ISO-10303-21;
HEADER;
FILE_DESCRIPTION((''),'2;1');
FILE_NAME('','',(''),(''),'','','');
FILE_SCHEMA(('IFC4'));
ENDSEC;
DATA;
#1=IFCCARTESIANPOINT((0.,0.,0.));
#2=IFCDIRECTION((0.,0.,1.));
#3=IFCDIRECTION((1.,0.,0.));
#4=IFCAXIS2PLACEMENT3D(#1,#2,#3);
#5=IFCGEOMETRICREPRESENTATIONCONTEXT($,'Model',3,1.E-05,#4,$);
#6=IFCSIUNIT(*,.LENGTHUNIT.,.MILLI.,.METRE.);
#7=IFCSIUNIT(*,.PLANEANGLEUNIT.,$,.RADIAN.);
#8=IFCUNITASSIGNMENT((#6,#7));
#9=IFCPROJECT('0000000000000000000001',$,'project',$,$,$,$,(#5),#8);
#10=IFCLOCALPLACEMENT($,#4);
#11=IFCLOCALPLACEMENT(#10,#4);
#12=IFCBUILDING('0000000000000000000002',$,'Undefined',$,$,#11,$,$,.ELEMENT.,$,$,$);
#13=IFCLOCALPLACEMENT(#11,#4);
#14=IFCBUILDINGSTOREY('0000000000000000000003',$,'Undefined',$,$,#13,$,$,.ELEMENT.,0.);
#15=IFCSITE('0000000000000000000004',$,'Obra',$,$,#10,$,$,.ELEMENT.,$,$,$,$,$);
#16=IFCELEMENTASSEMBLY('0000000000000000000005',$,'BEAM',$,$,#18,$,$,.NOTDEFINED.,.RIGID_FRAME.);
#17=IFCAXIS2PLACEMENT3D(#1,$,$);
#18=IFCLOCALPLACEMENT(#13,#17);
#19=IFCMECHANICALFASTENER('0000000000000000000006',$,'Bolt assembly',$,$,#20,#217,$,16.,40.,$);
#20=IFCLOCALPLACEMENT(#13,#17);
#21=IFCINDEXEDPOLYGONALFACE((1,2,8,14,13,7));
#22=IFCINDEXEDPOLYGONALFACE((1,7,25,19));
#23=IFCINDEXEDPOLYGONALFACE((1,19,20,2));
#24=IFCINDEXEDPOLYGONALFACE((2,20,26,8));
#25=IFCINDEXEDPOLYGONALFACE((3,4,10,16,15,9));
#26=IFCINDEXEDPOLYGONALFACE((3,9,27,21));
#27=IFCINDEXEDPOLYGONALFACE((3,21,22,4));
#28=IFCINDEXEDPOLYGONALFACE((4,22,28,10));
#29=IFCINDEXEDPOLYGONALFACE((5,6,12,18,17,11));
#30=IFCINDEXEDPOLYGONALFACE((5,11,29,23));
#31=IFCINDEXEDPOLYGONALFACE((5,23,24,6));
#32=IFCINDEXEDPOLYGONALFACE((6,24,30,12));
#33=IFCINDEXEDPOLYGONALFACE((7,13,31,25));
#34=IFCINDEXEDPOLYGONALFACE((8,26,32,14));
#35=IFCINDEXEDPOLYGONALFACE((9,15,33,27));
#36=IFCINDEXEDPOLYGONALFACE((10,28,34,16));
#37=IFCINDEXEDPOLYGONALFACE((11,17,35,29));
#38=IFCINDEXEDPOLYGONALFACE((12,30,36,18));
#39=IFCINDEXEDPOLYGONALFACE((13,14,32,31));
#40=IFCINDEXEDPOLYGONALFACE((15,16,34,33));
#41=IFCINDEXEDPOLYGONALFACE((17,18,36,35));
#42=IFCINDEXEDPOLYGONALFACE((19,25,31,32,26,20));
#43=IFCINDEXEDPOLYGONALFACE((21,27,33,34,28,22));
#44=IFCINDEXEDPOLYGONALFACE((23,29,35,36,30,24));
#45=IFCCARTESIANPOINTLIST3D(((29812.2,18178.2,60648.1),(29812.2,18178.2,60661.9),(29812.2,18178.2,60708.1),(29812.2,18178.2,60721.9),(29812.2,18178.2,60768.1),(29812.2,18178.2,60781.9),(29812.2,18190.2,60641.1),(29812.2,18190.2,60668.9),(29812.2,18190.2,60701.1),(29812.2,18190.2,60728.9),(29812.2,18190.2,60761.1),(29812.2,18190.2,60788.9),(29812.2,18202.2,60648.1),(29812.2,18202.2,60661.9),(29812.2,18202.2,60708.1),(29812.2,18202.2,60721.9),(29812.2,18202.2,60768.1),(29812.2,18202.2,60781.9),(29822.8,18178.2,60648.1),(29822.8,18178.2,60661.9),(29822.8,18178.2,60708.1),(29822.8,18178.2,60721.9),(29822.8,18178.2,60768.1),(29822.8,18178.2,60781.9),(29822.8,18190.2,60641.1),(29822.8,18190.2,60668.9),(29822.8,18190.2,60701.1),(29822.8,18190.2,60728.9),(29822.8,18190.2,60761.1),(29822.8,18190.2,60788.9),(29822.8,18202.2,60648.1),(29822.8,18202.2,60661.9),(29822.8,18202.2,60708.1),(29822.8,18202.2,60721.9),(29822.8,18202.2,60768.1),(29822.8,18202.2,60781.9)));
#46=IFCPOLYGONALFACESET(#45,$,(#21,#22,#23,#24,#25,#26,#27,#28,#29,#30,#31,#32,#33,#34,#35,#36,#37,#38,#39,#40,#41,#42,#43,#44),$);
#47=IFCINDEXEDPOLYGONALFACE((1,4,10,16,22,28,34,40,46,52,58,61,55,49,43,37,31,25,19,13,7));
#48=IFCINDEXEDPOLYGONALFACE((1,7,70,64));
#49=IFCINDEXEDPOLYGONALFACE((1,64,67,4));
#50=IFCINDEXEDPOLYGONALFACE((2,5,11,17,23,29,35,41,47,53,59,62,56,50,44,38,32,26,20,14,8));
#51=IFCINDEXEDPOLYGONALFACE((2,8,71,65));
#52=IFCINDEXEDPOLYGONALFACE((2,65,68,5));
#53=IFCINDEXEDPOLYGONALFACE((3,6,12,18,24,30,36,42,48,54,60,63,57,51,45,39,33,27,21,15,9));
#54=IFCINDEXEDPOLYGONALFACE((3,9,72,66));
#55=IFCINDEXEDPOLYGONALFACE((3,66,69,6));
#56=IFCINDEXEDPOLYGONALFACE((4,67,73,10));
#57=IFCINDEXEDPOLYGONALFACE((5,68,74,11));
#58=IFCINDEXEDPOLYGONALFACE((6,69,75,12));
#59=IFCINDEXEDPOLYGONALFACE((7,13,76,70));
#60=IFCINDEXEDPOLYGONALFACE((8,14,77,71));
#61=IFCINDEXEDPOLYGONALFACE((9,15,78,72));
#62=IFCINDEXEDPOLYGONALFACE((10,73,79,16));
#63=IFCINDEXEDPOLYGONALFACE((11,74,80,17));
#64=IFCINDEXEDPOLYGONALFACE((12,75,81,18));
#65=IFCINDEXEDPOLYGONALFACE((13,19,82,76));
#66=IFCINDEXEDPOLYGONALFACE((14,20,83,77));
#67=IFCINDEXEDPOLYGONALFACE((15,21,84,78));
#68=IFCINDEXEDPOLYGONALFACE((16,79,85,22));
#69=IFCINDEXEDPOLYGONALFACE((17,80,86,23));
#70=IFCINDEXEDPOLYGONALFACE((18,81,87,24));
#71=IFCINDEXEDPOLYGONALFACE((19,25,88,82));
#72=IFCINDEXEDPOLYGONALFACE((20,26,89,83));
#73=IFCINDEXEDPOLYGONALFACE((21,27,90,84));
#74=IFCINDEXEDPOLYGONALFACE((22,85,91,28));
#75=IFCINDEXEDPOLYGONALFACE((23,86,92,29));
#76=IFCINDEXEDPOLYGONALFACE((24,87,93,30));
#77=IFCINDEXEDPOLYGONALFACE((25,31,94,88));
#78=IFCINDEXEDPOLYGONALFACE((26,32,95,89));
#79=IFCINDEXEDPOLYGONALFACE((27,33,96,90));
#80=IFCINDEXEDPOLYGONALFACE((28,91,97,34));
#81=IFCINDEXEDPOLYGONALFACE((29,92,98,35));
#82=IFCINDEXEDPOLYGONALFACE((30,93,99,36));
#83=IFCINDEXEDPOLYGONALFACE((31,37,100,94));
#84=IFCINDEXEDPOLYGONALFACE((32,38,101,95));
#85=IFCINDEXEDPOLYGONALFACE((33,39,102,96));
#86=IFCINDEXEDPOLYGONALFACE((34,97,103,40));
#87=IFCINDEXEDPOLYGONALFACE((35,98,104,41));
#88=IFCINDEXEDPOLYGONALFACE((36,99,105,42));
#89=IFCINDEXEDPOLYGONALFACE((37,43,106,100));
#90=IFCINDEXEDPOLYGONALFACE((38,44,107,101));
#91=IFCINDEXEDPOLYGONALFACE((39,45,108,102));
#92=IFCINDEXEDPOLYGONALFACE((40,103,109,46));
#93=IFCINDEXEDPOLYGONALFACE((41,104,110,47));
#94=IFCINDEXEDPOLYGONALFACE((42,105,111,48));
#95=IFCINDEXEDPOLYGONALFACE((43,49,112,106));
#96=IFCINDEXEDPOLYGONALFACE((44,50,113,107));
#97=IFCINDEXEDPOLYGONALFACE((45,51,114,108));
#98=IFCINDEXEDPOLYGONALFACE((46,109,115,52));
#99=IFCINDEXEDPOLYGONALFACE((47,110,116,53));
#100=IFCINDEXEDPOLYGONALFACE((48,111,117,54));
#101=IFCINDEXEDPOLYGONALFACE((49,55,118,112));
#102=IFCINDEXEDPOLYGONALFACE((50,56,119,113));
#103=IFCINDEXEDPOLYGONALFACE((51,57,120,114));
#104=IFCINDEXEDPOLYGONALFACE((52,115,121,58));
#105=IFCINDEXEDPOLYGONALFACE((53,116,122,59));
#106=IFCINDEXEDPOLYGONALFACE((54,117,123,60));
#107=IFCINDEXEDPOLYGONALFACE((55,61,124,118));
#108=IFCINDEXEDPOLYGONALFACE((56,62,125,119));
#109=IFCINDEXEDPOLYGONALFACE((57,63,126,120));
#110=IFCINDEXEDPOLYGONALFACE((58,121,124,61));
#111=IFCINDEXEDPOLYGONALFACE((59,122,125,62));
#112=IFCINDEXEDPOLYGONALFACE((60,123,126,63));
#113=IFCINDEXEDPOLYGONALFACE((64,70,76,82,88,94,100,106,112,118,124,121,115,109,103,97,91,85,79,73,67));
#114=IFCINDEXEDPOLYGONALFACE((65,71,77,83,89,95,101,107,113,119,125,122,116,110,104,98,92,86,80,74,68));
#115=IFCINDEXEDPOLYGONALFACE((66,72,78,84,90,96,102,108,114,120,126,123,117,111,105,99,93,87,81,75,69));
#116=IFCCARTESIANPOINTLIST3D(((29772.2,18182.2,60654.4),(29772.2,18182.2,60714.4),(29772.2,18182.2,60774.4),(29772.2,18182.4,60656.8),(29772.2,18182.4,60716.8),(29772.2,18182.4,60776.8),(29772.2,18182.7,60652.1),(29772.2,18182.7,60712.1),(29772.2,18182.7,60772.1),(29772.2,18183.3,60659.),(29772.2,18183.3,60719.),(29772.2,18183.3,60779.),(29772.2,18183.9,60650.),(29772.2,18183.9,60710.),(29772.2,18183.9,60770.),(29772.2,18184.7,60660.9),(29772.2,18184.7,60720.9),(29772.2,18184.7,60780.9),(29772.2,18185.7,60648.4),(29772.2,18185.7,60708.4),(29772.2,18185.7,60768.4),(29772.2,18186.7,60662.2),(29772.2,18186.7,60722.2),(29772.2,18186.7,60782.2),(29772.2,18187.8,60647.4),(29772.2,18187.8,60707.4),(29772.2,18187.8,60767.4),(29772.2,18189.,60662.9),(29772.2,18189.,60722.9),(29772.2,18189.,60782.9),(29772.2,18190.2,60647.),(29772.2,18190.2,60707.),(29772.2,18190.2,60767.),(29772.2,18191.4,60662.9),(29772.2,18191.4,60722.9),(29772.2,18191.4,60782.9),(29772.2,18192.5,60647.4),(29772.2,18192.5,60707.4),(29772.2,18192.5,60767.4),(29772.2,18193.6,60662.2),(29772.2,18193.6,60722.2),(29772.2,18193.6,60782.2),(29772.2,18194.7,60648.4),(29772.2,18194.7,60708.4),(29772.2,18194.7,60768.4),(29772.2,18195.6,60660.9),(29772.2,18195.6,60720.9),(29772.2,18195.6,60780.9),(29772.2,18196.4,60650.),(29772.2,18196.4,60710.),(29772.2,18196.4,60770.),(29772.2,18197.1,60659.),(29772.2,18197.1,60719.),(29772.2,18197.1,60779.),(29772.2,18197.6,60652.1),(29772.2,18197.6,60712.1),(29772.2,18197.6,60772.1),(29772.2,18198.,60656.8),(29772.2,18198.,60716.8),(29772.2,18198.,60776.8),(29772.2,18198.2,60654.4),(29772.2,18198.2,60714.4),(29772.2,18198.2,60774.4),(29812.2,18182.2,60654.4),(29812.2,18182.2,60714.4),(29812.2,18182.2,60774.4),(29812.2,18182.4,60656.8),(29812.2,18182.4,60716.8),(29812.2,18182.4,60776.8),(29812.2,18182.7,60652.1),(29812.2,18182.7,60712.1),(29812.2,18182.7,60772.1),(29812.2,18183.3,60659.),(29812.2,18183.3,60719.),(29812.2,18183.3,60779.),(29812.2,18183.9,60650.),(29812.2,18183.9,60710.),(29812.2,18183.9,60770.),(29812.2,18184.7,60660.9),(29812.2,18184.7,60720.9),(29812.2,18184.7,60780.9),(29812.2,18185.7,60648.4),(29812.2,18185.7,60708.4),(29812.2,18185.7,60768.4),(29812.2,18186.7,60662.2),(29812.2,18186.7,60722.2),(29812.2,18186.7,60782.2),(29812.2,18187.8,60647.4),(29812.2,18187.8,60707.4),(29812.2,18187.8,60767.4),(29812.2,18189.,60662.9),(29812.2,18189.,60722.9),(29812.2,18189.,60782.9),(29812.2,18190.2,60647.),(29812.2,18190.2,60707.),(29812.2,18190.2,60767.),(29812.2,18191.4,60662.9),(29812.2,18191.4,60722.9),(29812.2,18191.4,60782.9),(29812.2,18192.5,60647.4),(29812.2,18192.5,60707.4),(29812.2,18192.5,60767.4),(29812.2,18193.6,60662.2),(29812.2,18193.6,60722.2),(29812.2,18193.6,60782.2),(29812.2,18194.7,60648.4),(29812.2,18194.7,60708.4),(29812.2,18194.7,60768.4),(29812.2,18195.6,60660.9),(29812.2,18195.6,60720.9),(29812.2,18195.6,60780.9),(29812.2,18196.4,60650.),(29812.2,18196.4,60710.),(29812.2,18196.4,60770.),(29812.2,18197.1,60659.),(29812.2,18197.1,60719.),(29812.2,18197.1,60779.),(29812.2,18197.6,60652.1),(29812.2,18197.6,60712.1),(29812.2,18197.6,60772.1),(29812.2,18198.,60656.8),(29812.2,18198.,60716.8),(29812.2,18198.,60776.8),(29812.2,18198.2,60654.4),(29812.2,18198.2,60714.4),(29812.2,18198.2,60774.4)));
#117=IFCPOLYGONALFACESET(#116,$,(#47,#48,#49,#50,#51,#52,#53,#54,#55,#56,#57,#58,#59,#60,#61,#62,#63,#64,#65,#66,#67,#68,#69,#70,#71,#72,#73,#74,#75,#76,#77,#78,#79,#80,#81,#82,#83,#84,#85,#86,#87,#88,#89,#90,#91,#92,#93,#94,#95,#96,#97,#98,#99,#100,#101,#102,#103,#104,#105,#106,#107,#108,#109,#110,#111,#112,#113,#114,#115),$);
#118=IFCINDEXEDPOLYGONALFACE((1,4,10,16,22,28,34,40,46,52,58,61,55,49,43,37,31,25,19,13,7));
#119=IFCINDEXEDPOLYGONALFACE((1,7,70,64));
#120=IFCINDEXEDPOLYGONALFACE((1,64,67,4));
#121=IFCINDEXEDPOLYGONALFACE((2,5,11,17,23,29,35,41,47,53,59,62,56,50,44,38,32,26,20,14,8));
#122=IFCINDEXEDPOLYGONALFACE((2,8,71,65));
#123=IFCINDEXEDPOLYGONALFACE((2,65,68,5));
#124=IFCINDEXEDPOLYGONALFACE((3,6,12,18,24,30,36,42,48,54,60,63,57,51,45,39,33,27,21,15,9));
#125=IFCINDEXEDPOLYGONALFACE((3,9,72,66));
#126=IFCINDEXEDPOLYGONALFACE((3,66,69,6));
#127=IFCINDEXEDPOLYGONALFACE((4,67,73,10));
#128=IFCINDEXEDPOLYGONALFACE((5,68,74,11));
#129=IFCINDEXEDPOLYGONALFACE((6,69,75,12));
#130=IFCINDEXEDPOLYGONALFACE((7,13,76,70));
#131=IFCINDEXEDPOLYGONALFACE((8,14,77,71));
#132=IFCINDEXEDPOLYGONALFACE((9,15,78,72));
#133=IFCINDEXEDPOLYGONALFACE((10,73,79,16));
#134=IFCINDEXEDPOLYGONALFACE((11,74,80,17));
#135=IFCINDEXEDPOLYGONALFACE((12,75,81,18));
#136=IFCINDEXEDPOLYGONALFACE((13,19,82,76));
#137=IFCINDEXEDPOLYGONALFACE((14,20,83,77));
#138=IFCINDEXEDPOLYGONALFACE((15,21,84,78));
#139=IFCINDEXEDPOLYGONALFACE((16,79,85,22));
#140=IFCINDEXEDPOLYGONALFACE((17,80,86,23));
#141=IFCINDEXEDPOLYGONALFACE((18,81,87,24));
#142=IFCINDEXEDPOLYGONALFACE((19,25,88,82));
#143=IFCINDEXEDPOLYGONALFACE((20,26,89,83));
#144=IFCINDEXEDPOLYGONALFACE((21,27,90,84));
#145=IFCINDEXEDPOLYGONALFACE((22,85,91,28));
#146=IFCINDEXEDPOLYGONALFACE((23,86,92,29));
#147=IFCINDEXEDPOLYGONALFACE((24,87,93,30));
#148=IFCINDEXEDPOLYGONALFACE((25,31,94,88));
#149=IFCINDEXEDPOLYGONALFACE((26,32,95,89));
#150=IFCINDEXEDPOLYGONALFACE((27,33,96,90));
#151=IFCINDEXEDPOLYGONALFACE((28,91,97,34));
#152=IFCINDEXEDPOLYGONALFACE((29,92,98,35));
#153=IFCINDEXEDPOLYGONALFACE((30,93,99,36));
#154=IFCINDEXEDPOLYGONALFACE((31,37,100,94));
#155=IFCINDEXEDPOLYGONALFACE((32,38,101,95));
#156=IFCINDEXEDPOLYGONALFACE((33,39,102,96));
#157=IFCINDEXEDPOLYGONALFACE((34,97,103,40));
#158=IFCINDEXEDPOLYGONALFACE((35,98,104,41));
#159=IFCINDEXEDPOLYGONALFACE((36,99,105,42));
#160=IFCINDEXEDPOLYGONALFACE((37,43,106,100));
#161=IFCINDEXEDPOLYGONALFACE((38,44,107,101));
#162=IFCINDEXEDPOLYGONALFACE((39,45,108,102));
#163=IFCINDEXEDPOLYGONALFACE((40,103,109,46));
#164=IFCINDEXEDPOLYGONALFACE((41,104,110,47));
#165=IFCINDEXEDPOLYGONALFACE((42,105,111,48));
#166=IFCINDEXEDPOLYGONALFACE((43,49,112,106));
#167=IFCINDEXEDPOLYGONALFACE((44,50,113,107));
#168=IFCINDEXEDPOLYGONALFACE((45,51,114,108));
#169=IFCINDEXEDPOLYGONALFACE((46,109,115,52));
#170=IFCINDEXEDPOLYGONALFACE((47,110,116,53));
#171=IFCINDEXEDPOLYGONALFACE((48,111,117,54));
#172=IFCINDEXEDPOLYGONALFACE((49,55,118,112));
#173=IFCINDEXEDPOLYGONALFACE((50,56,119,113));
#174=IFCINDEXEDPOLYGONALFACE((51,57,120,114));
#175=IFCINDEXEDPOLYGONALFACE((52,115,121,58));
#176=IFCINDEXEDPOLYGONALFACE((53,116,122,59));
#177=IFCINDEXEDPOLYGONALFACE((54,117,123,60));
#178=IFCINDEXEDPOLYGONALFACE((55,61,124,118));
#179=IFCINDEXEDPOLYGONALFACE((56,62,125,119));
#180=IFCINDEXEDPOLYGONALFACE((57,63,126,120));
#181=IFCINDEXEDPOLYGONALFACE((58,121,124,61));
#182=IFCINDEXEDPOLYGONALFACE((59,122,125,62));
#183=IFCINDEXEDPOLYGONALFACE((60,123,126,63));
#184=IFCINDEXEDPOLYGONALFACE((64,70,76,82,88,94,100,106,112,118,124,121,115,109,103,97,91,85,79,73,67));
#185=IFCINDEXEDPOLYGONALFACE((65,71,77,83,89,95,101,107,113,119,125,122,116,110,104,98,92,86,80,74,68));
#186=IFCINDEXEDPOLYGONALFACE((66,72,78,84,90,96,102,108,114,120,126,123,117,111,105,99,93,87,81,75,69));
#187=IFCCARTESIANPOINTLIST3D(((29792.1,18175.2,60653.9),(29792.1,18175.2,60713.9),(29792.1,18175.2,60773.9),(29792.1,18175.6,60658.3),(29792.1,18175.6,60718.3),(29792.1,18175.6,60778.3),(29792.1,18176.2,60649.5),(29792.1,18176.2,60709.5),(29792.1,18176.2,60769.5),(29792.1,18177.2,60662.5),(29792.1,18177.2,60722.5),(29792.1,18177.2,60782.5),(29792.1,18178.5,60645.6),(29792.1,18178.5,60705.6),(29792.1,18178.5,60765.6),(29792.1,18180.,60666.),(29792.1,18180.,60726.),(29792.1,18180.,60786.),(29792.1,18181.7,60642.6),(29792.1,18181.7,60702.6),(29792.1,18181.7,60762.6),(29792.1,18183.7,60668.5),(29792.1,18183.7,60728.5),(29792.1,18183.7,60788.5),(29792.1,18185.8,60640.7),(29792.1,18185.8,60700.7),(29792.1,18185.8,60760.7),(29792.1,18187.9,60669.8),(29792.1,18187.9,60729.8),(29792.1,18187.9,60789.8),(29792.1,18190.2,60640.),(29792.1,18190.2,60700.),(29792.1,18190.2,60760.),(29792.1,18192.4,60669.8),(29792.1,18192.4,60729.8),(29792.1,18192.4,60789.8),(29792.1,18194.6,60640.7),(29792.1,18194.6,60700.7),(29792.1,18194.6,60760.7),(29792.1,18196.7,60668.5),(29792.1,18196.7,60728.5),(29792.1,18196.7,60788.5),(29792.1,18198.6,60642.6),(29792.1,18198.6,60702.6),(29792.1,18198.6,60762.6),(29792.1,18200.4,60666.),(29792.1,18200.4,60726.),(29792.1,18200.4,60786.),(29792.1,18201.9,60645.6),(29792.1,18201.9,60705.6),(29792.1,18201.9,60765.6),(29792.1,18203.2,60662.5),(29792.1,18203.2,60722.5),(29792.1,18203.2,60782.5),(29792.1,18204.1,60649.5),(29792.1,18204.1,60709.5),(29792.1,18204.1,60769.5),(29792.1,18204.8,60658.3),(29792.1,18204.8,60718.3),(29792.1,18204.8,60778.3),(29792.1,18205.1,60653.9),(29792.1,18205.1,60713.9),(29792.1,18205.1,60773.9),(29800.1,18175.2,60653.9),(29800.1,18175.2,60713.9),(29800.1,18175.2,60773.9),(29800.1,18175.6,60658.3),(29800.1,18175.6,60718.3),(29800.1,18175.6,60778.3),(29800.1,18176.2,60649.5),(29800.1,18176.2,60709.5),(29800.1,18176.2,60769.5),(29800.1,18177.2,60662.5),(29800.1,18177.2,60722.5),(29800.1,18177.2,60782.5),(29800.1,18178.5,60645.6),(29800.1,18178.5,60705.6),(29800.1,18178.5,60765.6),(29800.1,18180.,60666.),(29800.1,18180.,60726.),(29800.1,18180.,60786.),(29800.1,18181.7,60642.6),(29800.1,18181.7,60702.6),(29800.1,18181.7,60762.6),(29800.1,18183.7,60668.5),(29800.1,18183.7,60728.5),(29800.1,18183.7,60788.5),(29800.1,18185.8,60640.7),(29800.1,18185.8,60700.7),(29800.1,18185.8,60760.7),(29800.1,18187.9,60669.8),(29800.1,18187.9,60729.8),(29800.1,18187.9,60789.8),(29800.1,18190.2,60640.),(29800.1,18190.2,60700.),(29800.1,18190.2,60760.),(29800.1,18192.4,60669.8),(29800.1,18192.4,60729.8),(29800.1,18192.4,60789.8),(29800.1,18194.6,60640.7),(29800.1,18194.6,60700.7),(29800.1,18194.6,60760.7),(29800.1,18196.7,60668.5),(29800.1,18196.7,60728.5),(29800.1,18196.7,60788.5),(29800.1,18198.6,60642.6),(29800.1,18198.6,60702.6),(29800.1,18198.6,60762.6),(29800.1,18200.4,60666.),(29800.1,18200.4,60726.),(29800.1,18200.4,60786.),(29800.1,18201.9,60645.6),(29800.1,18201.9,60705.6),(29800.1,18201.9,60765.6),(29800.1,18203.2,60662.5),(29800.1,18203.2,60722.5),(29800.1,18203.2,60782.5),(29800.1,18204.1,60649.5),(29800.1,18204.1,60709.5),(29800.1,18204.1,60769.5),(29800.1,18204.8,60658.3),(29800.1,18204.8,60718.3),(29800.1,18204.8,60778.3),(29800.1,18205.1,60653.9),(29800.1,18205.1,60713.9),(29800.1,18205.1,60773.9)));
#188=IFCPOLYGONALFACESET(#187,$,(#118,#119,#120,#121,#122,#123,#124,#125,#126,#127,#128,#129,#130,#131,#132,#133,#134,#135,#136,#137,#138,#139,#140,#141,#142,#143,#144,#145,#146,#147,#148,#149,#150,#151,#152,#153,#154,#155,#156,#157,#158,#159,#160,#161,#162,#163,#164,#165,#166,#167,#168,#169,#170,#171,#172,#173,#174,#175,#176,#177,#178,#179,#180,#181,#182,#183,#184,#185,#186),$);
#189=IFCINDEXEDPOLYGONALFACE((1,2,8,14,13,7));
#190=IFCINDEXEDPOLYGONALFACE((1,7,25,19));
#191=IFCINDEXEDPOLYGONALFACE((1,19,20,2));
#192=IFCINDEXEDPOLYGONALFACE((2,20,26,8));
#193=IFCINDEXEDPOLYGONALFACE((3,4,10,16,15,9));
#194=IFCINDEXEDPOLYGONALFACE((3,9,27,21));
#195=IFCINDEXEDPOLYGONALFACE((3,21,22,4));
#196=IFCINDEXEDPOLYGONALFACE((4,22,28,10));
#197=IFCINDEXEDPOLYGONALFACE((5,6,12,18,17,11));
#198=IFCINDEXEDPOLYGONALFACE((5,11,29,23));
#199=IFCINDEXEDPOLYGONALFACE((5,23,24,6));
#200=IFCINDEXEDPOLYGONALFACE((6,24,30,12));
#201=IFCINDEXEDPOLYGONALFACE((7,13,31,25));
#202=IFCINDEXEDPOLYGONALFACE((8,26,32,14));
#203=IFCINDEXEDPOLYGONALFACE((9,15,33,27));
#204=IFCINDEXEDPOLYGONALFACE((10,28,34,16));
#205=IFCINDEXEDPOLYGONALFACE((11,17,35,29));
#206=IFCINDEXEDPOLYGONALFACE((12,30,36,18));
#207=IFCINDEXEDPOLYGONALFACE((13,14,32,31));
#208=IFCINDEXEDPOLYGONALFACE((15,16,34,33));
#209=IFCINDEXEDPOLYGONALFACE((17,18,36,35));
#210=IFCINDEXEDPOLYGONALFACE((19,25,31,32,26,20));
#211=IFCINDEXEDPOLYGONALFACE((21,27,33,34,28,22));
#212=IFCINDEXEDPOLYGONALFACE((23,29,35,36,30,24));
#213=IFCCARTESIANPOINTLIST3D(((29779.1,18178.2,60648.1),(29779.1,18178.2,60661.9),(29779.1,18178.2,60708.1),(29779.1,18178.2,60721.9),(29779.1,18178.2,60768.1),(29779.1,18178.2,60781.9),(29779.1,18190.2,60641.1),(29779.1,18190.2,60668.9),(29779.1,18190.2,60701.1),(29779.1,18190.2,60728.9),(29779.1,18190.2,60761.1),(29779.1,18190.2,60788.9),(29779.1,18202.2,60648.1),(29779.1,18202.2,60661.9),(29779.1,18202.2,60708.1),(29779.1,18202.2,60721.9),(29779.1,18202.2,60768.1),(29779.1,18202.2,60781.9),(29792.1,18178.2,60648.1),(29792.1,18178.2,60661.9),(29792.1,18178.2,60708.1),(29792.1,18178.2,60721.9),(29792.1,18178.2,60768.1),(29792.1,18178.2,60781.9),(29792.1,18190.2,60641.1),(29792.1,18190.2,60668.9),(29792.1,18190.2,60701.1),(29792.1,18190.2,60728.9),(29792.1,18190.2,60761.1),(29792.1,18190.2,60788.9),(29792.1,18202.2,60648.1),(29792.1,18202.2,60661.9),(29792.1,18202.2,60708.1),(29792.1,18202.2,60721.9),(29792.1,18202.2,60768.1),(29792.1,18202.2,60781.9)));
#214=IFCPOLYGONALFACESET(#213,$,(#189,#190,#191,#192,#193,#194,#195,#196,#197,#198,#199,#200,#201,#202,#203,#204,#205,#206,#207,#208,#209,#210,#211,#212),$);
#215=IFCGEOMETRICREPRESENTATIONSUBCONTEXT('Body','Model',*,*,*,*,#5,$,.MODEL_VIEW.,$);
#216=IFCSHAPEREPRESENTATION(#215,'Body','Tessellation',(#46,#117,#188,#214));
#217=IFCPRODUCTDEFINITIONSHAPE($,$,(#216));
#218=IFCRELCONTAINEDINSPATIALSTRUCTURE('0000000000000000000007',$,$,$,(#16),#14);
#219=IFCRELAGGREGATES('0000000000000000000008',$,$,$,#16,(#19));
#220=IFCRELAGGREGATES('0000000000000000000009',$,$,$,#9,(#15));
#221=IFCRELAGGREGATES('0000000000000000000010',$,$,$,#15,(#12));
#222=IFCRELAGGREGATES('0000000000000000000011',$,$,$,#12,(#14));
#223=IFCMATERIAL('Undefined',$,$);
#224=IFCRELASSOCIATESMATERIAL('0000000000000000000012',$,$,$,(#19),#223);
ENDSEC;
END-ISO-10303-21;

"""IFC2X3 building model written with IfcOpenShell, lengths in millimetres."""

from ifc_helpers import new_model, si_unit, frame, origin_with_axes, origin_2d_with_axis, place, context, subcontext, project, spatial, polyline, circle, outline, extrude, source, transform, mapped, material, element, aggregate, save


model = new_model("IFC2X3")

# Units and contexts
model_context = context("Model", 3, precision=1e-05, world=origin_with_axes())
body_context = subcontext(model_context, "Body", "Model", "MODEL_VIEW")
ifc_project = project(units=[si_unit("LENGTHUNIT", "METRE", prefix="MILLI"), si_unit("PLANEANGLEUNIT", "RADIAN")], contexts=[model_context])

# Site, building, storey
site_placement = place(None, origin_with_axes())
site = spatial("IfcSite", under=ifc_project, at=site_placement, Name="Obra", CompositionType="ELEMENT")
building_placement = place(site_placement, origin_with_axes())
building = spatial("IfcBuilding", under=site, at=building_placement, Name="Undefined", CompositionType="ELEMENT")
storey_placement = place(building_placement, origin_with_axes())
storey = spatial("IfcBuildingStorey", under=building, at=storey_placement, Name="Undefined", CompositionType="ELEMENT", Elevation=0.0)

# Element assembly, mechanical fastener
assembly_1_placement = place(storey_placement, origin_with_axes())
assembly_1 = element("IfcElementAssembly", 1, at=assembly_1_placement, inside=storey, Name="BEAM", AssemblyPlace="NOTDEFINED", PredefinedType="RIGID_FRAME")
ifc_material_1 = material(Name="Undefined")
shared_shape_1 = source(origin_with_axes(), body_context, "Body", "SweptSolid", [
    extrude(outline(polyline([(13.9, 0.0), (6.9, 12.0), (-6.9, 12.0), (-13.9, 0.0), (-6.9, -12.0), (6.9, -12.0), (13.9, 0.0)])), frame((0.0, -19.7, 0.0), z_axis=(0.0, 1.0, 0.0), x_axis=(1.0, 0.0, 0.0)), (0.0, 0.0, 1.0), 10.6),
    extrude(circle(Radius=8.0, at=origin_2d_with_axis()), frame((0.0, -9.1, 0.0), z_axis=(0.0, 1.0, 0.0), x_axis=(1.0, 0.0, 0.0)), (0.0, 0.0, 1.0), 40.0),
    extrude(circle(Radius=15.0, at=origin_2d_with_axis()), frame((0.0, 3.0, 0.0), z_axis=(0.0, 1.0, 0.0), x_axis=(1.0, 0.0, 0.0)), (0.0, 0.0, 1.0), 8.0),
    extrude(outline(polyline([(13.9, 0.0), (6.9, 12.0), (-6.9, 12.0), (-13.9, 0.0), (-6.9, -12.0), (6.9, -12.0), (13.9, 0.0)])), frame((0.0, 11.0, 0.0), z_axis=(0.0, 1.0, 0.0), x_axis=(1.0, 0.0, 0.0)), (0.0, 0.0, 1.0), 13.0),
])
mechanical_fastener_1_placement = place(assembly_1_placement, frame((29803.1, 18140.2, 60835.0), z_axis=(-0.000002, 1.0, 0.0), x_axis=(0.0, 0.0, -1.0)))
mechanical_fastener_1 = element("IfcMechanicalFastener", 2, at=mechanical_fastener_1_placement, material=ifc_material_1, Name="Bolt assembly", NominalDiameter=16.0, NominalLength=40.0, context=body_context, shape_type="MappedRepresentation", body=[
    mapped(shared_shape_1, transform((60.0, 0.0, 50.0))),
    mapped(shared_shape_1, transform((120.0, 0.0, 50.0))),
    mapped(shared_shape_1, transform((180.0, 0.0, 50.0))),
])

aggregate(assembly_1, [mechanical_fastener_1])

save(model, "model.ifc")
